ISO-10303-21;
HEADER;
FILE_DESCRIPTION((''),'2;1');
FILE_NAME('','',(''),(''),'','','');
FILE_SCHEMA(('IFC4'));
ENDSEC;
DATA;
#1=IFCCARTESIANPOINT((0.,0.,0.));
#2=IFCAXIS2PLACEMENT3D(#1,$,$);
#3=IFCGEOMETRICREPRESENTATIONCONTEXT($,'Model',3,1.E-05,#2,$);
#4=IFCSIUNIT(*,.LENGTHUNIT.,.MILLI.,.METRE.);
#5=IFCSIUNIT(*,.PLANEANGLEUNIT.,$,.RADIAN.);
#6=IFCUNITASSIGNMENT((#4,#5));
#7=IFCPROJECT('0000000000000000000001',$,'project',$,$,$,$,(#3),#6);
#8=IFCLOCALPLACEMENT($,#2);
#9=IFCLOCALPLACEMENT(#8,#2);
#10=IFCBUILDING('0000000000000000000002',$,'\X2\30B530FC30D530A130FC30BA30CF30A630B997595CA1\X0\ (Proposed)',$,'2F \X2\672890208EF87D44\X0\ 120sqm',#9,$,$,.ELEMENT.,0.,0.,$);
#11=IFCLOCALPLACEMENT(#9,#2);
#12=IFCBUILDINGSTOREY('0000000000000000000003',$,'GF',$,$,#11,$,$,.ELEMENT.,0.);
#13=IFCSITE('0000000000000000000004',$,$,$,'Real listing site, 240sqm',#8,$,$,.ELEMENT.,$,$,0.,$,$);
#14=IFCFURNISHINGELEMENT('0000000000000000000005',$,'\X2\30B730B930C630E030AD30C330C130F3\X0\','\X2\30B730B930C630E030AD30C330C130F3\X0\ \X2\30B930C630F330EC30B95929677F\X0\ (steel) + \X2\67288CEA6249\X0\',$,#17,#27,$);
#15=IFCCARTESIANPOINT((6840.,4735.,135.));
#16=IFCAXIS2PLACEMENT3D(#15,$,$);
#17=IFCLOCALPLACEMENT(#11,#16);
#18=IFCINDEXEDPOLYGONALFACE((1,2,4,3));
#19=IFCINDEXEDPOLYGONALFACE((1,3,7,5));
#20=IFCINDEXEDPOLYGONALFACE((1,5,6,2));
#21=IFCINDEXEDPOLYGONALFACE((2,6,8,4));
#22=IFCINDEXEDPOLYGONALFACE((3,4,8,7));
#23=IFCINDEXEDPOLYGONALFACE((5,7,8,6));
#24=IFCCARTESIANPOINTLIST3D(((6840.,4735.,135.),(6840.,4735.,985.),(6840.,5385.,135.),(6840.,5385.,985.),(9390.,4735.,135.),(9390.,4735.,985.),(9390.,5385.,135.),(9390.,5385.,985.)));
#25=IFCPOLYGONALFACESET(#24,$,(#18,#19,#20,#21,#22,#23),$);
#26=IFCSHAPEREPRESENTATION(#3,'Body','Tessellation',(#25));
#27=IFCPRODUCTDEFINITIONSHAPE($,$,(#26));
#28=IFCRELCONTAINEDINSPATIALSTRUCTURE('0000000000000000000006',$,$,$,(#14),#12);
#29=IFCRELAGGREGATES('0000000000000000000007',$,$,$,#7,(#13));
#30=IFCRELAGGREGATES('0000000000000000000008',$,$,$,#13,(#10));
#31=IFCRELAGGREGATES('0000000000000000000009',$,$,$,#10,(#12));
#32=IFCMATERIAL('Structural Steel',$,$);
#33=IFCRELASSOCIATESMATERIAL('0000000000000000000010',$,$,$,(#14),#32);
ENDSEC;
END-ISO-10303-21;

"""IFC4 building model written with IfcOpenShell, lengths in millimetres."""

from ifc_helpers import new_model, si_unit, frame, frame_2d, origin, place, context, project, spatial, rectangle, extrude, material, element, save


model = new_model("IFC4")

# Units and contexts
model_context = context("Model", 3, precision=1e-05, world=origin())
ifc_project = project(units=[si_unit("LENGTHUNIT", "METRE", prefix="MILLI"), si_unit("PLANEANGLEUNIT", "RADIAN")], contexts=[model_context])

# Site, building, storey
site_placement = place(None, origin())
site = spatial("IfcSite", under=ifc_project, at=site_placement, ObjectType="Real listing site, 240sqm", CompositionType="ELEMENT", RefElevation=0.0)
building_placement = place(site_placement, origin())
building = spatial("IfcBuilding", under=site, at=building_placement, Name="サーファーズハウス静岡 (Proposed)", ObjectType="2F 木造軸組 120sqm", CompositionType="ELEMENT", ElevationOfRefHeight=0.0, ElevationOfTerrain=0.0)
storey_placement = place(building_placement, origin())
storey = spatial("IfcBuildingStorey", under=building, at=storey_placement, Name="GF", CompositionType="ELEMENT", Elevation=0.0)

# Shared definitions
ifc_material_1 = material(Name="Structural Steel")

# Furnishing element
furnishing_placement = place(storey_placement, frame((6840.0, 4735.0, 135.0)))
element("IfcFurnishingElement", 1, at=furnishing_placement, inside=storey, material=ifc_material_1, Name="システムキッチン", Description="システムキッチン ステンレス天板 (steel) + 木質扉", context=model_context, shape_type="SweptSolid", body=[
    extrude(rectangle(XDim=2550.0, YDim=650.0, at=frame_2d((1275.0, 325.0))), frame((6840.0, 4735.0, 135.0)), (0.0, 0.0, 1.0), 850.0),
])

save(model, "model.ifc")
